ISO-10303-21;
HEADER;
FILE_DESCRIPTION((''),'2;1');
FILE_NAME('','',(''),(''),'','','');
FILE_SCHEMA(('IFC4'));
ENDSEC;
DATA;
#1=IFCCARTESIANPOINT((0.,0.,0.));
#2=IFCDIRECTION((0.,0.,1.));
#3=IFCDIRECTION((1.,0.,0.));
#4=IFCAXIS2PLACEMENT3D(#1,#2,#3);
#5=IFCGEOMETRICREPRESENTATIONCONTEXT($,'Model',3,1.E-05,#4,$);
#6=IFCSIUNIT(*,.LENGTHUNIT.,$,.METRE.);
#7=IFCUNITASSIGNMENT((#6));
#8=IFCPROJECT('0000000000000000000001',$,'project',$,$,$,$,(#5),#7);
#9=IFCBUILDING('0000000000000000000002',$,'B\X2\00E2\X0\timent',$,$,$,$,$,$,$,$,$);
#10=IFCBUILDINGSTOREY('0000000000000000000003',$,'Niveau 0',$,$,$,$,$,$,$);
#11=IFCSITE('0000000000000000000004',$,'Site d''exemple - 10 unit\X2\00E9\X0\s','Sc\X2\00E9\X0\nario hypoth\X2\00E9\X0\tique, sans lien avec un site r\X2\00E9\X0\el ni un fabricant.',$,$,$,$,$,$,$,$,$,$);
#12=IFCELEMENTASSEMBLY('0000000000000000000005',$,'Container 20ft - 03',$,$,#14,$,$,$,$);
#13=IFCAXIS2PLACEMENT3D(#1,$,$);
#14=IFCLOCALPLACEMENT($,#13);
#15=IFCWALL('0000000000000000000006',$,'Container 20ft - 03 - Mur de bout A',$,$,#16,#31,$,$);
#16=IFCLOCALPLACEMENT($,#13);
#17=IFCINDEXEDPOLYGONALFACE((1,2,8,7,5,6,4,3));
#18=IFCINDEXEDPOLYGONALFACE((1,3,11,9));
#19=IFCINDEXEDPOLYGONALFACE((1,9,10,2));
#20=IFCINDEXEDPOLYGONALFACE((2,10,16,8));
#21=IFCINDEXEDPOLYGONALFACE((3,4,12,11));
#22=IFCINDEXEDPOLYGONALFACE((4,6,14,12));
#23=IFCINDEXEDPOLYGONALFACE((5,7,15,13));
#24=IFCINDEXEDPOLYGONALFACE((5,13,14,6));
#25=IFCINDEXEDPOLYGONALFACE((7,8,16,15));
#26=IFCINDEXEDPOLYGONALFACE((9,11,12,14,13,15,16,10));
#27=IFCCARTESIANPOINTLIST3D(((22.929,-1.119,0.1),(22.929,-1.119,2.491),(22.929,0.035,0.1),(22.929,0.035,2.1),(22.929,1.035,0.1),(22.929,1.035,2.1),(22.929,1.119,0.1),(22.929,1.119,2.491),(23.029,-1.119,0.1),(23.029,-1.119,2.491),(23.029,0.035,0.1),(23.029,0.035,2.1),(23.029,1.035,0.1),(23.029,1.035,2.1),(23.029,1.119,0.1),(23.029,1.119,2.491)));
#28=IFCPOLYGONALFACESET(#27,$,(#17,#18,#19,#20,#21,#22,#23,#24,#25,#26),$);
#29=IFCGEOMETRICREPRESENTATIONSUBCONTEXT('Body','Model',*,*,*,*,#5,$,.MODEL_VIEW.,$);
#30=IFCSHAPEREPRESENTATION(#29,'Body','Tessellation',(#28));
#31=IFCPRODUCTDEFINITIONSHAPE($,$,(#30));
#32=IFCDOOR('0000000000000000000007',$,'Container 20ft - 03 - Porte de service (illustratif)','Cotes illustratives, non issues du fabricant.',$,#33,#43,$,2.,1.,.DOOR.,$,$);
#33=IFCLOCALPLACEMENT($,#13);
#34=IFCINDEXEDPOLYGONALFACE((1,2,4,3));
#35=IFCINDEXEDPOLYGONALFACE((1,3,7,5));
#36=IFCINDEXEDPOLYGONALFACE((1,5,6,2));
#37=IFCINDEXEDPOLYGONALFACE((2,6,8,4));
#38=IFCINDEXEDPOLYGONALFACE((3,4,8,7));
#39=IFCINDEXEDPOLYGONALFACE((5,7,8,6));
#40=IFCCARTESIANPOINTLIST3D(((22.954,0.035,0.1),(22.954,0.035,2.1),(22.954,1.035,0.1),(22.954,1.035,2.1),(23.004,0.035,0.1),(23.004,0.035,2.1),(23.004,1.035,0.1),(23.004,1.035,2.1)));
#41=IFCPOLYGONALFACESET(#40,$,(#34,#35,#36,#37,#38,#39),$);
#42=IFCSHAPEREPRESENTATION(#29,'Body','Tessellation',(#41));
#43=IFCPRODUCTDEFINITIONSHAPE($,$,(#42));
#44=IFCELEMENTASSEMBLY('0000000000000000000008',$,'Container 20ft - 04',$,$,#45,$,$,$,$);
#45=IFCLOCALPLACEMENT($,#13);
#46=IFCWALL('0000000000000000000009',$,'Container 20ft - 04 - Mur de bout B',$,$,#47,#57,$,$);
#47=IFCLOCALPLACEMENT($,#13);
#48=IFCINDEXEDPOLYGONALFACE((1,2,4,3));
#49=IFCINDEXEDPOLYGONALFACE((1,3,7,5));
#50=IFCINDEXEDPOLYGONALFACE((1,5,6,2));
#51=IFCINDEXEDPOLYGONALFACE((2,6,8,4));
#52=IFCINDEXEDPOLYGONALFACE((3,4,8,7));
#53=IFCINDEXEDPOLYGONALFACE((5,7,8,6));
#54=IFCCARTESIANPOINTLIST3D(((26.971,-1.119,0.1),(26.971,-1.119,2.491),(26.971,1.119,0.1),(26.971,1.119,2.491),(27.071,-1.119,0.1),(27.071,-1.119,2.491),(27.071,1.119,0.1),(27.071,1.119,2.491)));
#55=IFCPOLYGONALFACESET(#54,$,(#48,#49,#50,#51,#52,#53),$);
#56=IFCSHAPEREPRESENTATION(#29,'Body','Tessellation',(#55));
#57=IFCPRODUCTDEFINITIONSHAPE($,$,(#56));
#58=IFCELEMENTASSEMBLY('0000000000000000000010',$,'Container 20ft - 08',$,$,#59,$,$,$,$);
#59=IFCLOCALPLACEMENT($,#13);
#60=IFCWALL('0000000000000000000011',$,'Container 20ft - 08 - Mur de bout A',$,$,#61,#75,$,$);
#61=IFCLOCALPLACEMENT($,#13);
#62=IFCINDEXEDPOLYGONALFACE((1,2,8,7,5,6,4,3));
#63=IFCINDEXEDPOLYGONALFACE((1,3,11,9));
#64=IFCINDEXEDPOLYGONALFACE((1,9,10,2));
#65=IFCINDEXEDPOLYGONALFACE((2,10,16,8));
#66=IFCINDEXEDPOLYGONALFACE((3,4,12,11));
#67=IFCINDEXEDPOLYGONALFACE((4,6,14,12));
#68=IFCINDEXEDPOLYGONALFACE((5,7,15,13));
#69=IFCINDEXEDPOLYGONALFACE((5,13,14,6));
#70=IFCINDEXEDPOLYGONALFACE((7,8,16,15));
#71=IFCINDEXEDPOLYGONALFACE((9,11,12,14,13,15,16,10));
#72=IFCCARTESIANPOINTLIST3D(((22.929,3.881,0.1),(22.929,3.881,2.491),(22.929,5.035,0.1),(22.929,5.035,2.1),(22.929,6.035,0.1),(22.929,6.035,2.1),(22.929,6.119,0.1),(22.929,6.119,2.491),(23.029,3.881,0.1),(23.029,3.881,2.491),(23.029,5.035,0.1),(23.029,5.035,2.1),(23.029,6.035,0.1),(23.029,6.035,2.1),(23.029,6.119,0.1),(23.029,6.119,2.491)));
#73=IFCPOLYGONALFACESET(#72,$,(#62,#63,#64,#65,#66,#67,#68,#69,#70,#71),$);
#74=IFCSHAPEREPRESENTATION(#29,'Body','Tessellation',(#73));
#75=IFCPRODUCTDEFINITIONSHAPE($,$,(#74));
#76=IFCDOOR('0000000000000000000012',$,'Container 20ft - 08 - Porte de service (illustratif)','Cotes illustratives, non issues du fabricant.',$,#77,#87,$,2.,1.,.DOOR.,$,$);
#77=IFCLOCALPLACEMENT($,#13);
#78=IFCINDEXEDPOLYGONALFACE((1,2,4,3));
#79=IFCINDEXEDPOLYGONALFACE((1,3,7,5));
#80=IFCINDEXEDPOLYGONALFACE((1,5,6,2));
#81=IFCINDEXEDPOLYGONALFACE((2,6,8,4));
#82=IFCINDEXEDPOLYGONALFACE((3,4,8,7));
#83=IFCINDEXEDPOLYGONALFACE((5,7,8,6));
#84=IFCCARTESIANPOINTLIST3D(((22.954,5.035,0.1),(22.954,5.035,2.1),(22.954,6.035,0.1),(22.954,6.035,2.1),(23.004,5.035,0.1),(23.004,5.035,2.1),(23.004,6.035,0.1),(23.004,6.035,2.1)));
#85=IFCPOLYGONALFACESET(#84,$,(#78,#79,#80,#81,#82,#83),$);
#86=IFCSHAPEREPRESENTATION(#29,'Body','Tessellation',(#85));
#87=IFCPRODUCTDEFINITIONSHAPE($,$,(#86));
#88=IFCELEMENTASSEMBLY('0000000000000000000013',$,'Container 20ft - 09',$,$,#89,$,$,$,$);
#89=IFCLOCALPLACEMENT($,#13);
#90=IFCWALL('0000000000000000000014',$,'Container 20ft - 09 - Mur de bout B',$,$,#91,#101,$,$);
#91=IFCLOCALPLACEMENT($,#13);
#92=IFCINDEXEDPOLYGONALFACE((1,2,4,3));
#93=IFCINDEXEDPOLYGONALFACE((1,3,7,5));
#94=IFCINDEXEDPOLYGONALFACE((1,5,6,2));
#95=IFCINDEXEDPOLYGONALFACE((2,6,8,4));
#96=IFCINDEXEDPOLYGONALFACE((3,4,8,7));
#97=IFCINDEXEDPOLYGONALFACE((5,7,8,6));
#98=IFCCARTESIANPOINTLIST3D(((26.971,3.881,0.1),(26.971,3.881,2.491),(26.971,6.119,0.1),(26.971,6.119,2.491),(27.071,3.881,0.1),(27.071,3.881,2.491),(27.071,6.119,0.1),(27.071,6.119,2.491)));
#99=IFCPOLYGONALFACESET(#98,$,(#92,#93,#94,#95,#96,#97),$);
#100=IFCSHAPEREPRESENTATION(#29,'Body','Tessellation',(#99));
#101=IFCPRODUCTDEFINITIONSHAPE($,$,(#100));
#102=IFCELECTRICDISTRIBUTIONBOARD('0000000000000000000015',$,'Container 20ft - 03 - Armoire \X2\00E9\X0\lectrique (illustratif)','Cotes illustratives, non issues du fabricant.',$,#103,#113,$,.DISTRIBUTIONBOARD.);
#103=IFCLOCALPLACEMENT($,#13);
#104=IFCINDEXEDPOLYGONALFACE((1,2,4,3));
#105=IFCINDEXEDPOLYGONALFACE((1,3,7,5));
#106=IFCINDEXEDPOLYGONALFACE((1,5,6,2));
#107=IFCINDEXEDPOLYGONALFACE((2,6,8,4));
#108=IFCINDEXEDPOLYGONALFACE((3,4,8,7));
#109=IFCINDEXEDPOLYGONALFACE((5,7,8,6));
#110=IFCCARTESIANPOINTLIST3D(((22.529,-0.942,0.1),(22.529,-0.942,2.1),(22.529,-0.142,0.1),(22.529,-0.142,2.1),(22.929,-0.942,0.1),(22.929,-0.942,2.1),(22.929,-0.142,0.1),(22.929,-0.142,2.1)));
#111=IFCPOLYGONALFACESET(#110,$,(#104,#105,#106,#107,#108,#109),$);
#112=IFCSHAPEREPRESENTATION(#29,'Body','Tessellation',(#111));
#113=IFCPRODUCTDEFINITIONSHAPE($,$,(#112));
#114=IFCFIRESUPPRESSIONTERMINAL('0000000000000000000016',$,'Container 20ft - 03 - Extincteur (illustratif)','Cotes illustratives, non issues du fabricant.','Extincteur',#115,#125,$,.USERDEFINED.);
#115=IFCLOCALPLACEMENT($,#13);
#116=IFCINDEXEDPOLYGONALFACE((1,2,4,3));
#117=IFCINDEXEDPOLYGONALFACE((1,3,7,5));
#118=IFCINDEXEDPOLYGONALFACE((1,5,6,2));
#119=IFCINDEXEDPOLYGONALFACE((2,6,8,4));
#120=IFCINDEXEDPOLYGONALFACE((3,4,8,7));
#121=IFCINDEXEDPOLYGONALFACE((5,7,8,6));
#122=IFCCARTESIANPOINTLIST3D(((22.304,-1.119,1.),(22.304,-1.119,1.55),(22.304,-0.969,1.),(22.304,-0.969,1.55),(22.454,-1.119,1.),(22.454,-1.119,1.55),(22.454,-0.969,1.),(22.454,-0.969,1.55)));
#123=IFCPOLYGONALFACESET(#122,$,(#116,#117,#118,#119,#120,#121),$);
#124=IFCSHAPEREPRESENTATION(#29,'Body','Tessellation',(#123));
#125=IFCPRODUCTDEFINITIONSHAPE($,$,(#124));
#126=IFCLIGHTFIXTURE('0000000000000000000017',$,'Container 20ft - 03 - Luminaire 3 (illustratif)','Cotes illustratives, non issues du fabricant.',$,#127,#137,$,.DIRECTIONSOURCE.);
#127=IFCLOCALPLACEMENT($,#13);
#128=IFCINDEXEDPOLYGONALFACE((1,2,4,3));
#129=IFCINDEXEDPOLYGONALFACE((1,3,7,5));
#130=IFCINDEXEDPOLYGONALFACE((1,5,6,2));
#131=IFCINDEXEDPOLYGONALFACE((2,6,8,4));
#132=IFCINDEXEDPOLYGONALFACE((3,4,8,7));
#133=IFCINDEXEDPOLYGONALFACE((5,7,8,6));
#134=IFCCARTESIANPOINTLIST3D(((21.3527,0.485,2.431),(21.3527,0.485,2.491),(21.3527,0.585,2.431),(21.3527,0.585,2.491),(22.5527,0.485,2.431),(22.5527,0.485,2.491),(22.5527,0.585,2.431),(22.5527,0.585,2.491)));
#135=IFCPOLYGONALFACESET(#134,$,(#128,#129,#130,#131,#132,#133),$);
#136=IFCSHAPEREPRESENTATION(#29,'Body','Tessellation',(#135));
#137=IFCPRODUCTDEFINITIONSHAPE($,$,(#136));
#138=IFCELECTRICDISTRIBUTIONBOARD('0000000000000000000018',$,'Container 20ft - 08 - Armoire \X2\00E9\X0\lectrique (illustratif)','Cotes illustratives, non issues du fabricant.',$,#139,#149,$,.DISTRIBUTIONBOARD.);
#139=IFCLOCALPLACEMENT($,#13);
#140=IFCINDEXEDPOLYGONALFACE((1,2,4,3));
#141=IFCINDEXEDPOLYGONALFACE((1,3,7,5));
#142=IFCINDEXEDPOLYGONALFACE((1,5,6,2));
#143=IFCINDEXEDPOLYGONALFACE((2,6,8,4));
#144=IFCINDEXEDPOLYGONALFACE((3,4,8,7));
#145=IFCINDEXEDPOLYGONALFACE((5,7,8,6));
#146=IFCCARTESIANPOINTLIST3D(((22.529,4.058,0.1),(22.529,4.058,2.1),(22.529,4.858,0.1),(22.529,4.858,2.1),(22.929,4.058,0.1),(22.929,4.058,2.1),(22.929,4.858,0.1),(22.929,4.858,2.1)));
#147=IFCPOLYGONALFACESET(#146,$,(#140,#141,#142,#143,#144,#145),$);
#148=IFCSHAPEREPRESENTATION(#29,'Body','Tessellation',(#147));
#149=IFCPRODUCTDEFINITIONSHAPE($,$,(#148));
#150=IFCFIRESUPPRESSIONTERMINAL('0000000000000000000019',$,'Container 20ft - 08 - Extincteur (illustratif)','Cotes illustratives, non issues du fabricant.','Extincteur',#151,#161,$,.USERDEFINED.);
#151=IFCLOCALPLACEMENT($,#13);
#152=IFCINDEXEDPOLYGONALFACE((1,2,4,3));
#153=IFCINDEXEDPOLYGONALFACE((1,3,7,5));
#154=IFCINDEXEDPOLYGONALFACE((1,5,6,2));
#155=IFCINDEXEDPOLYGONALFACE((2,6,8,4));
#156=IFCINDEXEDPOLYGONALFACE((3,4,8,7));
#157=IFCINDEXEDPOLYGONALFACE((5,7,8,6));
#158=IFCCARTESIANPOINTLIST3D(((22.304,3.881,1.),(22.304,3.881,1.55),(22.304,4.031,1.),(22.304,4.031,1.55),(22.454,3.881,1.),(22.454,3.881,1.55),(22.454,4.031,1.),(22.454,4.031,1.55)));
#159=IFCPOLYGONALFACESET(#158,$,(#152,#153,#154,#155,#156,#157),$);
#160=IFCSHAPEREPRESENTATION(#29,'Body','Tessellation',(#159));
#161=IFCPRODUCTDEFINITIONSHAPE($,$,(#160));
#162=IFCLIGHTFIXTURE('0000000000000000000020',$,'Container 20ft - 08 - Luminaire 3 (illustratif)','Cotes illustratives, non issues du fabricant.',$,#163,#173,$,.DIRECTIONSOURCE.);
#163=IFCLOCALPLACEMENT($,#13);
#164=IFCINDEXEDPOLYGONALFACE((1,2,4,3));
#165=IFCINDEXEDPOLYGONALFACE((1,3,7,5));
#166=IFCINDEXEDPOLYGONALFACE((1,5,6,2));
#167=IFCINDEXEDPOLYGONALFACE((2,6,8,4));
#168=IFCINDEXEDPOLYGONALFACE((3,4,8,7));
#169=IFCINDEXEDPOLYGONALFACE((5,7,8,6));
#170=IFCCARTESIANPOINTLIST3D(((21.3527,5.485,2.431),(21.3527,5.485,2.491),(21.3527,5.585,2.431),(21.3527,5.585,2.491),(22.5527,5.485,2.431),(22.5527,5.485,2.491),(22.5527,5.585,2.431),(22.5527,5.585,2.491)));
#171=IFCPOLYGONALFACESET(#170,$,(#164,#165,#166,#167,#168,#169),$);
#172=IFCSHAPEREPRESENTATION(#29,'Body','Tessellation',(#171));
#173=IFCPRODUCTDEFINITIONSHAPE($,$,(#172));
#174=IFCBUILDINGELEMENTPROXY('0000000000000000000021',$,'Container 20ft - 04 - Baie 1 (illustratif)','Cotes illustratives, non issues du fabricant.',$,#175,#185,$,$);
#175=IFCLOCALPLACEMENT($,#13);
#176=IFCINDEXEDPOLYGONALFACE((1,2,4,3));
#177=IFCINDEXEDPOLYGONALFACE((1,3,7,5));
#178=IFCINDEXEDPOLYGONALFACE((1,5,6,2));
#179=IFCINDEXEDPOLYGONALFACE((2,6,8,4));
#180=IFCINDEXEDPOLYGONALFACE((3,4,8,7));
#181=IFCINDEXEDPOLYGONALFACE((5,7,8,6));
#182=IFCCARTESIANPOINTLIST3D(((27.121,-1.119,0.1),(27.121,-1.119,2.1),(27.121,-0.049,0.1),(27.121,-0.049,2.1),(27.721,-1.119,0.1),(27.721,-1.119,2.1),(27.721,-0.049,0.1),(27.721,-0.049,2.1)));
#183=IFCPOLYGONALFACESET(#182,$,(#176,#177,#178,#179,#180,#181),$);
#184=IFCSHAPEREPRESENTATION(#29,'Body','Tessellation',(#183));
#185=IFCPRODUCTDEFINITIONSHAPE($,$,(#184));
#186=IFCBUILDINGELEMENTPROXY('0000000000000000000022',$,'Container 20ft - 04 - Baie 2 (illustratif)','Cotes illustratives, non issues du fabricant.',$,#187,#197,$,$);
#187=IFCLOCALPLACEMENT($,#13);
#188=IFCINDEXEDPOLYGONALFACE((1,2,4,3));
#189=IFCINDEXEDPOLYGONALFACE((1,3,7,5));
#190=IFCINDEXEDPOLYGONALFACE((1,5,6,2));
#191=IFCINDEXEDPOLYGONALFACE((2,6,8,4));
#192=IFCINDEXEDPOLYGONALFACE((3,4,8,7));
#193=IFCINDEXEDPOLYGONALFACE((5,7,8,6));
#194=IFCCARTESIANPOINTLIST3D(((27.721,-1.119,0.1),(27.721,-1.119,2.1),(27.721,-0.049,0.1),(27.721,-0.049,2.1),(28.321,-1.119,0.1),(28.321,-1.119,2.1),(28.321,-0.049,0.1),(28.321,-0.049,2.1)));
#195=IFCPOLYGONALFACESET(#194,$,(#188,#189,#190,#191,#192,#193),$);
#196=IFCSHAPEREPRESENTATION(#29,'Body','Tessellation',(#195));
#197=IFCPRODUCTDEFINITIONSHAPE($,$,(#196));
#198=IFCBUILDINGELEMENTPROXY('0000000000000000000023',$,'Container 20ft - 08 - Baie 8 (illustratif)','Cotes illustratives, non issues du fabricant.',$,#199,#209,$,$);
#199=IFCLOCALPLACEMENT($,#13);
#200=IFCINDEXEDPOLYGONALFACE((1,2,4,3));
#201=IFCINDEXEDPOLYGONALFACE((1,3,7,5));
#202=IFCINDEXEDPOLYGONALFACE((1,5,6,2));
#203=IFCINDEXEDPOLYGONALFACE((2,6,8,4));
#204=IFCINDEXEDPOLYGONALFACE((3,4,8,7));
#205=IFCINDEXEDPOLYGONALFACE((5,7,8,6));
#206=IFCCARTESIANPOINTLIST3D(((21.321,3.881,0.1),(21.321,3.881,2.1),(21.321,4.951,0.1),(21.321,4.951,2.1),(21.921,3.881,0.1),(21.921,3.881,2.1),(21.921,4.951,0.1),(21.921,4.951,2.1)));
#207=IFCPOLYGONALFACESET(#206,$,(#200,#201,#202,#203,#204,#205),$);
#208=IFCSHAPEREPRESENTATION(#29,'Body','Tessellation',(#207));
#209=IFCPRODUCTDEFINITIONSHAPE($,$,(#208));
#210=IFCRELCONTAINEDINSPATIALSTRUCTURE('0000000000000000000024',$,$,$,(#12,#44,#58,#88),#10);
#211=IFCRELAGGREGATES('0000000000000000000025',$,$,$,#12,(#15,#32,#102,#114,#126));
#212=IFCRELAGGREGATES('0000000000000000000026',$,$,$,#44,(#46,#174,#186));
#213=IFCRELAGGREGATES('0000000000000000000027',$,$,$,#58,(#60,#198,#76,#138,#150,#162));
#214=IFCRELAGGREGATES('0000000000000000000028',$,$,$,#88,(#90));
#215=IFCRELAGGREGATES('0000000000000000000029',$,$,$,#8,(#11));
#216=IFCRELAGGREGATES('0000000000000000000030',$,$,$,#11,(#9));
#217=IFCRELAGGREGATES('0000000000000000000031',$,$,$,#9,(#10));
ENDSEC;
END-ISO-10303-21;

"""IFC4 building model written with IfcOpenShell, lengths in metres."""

from ifc_helpers import new_model, si_unit, frame, origin_with_axes, place, context, subcontext, project, spatial, rectangle, extrude, element, fill, aggregate, save


model = new_model("IFC4")

# Units and contexts
model_context = context("Model", 3, precision=1e-05, world=origin_with_axes())
body_context = subcontext(model_context, "Body", "Model", "MODEL_VIEW")
ifc_project = project(units=[si_unit("LENGTHUNIT", "METRE")], contexts=[model_context])

# Site, building, storey
site = spatial("IfcSite", under=ifc_project, Name="Site d'exemple - 10 unités", Description="Scénario hypothétique, sans lien avec un site réel ni un fabricant.")
building = spatial("IfcBuilding", under=site, Name="Bâtiment")
storey = spatial("IfcBuildingStorey", under=building, Name="Niveau 0")

# Element assembly, wall, opening, door
assembly_1 = element("IfcElementAssembly", 1, inside=storey, Name="Container 20ft - 03")
wall_1_placement = place(None, frame((22.979, 0.0, 0.1), z_axis=(0.0, 0.0, 1.0), x_axis=(1.0, 0.0, 0.0)))
wall_1 = element("IfcWall", 2, at=wall_1_placement, Name="Container 20ft - 03 - Mur de bout A", context=body_context, shape_type="SweptSolid", body=[
    extrude(rectangle(XDim=0.1, YDim=2.238), origin_with_axes(), (0.0, 0.0, 1.0), 2.391),
])
opening_1_placement = place(None, frame((22.979, 0.535, 0.1), z_axis=(0.0, 0.0, 1.0), x_axis=(1.0, 0.0, 0.0)))
opening_1 = element("IfcOpeningElement", 3, at=opening_1_placement, cuts=wall_1, PredefinedType="OPENING", context=body_context, shape_type="SweptSolid", body=[
    extrude(rectangle(XDim=0.2, YDim=1.0), origin_with_axes(), (0.0, 0.0, 1.0), 2.0),
])
door_1_placement = place(None, frame((22.979, 0.535, 0.1), z_axis=(0.0, 0.0, 1.0), x_axis=(1.0, 0.0, 0.0)))
door_1 = element("IfcDoor", 4, at=door_1_placement, Name="Container 20ft - 03 - Porte de service (illustratif)", Description="Cotes illustratives, non issues du fabricant.", OverallHeight=2.0, OverallWidth=1.0, PredefinedType="DOOR", context=body_context, shape_type="SweptSolid", body=[
    extrude(rectangle(XDim=0.05, YDim=1.0), origin_with_axes(), (0.0, 0.0, 1.0), 2.0),
])
fill(opening_1, door_1)

# Element assembly, wall
assembly_2 = element("IfcElementAssembly", 5, inside=storey, Name="Container 20ft - 04")
wall_2_placement = place(None, frame((27.021, 0.0, 0.1), z_axis=(0.0, 0.0, 1.0), x_axis=(1.0, 0.0, 0.0)))
wall_2 = element("IfcWall", 6, at=wall_2_placement, Name="Container 20ft - 04 - Mur de bout B", context=body_context, shape_type="SweptSolid", body=[
    extrude(rectangle(XDim=0.1, YDim=2.238), origin_with_axes(), (0.0, 0.0, 1.0), 2.391),
])

# Element assembly, wall, opening, door
assembly_3 = element("IfcElementAssembly", 7, inside=storey, Name="Container 20ft - 08")
wall_3_placement = place(None, frame((22.979, 5.0, 0.1), z_axis=(0.0, 0.0, 1.0), x_axis=(1.0, 0.0, 0.0)))
wall_3 = element("IfcWall", 8, at=wall_3_placement, Name="Container 20ft - 08 - Mur de bout A", context=body_context, shape_type="SweptSolid", body=[
    extrude(rectangle(XDim=0.1, YDim=2.238), origin_with_axes(), (0.0, 0.0, 1.0), 2.391),
])
opening_2_placement = place(None, frame((22.979, 5.535, 0.1), z_axis=(0.0, 0.0, 1.0), x_axis=(1.0, 0.0, 0.0)))
opening_2 = element("IfcOpeningElement", 9, at=opening_2_placement, cuts=wall_3, PredefinedType="OPENING", context=body_context, shape_type="SweptSolid", body=[
    extrude(rectangle(XDim=0.2, YDim=1.0), origin_with_axes(), (0.0, 0.0, 1.0), 2.0),
])
door_2_placement = place(None, frame((22.979, 5.535, 0.1), z_axis=(0.0, 0.0, 1.0), x_axis=(1.0, 0.0, 0.0)))
door_2 = element("IfcDoor", 10, at=door_2_placement, Name="Container 20ft - 08 - Porte de service (illustratif)", Description="Cotes illustratives, non issues du fabricant.", OverallHeight=2.0, OverallWidth=1.0, PredefinedType="DOOR", context=body_context, shape_type="SweptSolid", body=[
    extrude(rectangle(XDim=0.05, YDim=1.0), origin_with_axes(), (0.0, 0.0, 1.0), 2.0),
])
fill(opening_2, door_2)

# Element assembly, wall
assembly_4 = element("IfcElementAssembly", 11, inside=storey, Name="Container 20ft - 09")
wall_4_placement = place(None, frame((27.021, 5.0, 0.1), z_axis=(0.0, 0.0, 1.0), x_axis=(1.0, 0.0, 0.0)))
wall_4 = element("IfcWall", 12, at=wall_4_placement, Name="Container 20ft - 09 - Mur de bout B", context=body_context, shape_type="SweptSolid", body=[
    extrude(rectangle(XDim=0.1, YDim=2.238), origin_with_axes(), (0.0, 0.0, 1.0), 2.391),
])

# Electric distribution board
electric_distribution_board_1_placement = place(None, frame((22.729, -0.542, 0.1), z_axis=(0.0, 0.0, 1.0), x_axis=(1.0, 0.0, 0.0)))
electric_distribution_board_1 = element("IfcElectricDistributionBoard", 13, at=electric_distribution_board_1_placement, Name="Container 20ft - 03 - Armoire électrique (illustratif)", Description="Cotes illustratives, non issues du fabricant.", PredefinedType="DISTRIBUTIONBOARD", context=body_context, shape_type="SweptSolid", body=[
    extrude(rectangle(XDim=0.4, YDim=0.8), origin_with_axes(), (0.0, 0.0, 1.0), 2.0),
])

# Fire suppression terminal
fire_suppression_terminal_1_placement = place(None, frame((22.379, -1.044, 1.0), z_axis=(0.0, 0.0, 1.0), x_axis=(1.0, 0.0, 0.0)))
fire_suppression_terminal_1 = element("IfcFireSuppressionTerminal", 14, at=fire_suppression_terminal_1_placement, Name="Container 20ft - 03 - Extincteur (illustratif)", Description="Cotes illustratives, non issues du fabricant.", ObjectType="Extincteur", PredefinedType="USERDEFINED", context=body_context, shape_type="SweptSolid", body=[
    extrude(rectangle(XDim=0.15, YDim=0.15), origin_with_axes(), (0.0, 0.0, 1.0), 0.55),
])

# Light fixture
light_fixture_1_placement = place(None, frame((21.9527, 0.535, 2.431), z_axis=(0.0, 0.0, 1.0), x_axis=(1.0, 0.0, 0.0)))
light_fixture_1 = element("IfcLightFixture", 15, at=light_fixture_1_placement, Name="Container 20ft - 03 - Luminaire 3 (illustratif)", Description="Cotes illustratives, non issues du fabricant.", PredefinedType="DIRECTIONSOURCE", context=body_context, shape_type="SweptSolid", body=[
    extrude(rectangle(XDim=1.2, YDim=0.1), origin_with_axes(), (0.0, 0.0, 1.0), 0.06),
])
aggregate(assembly_1, [wall_1, door_1, electric_distribution_board_1, fire_suppression_terminal_1, light_fixture_1])

# Electric distribution board
electric_distribution_board_2_placement = place(None, frame((22.729, 4.458, 0.1), z_axis=(0.0, 0.0, 1.0), x_axis=(1.0, 0.0, 0.0)))
electric_distribution_board_2 = element("IfcElectricDistributionBoard", 16, at=electric_distribution_board_2_placement, Name="Container 20ft - 08 - Armoire électrique (illustratif)", Description="Cotes illustratives, non issues du fabricant.", PredefinedType="DISTRIBUTIONBOARD", context=body_context, shape_type="SweptSolid", body=[
    extrude(rectangle(XDim=0.4, YDim=0.8), origin_with_axes(), (0.0, 0.0, 1.0), 2.0),
])

# Fire suppression terminal
fire_suppression_terminal_2_placement = place(None, frame((22.379, 3.956, 1.0), z_axis=(0.0, 0.0, 1.0), x_axis=(1.0, 0.0, 0.0)))
fire_suppression_terminal_2 = element("IfcFireSuppressionTerminal", 17, at=fire_suppression_terminal_2_placement, Name="Container 20ft - 08 - Extincteur (illustratif)", Description="Cotes illustratives, non issues du fabricant.", ObjectType="Extincteur", PredefinedType="USERDEFINED", context=body_context, shape_type="SweptSolid", body=[
    extrude(rectangle(XDim=0.15, YDim=0.15), origin_with_axes(), (0.0, 0.0, 1.0), 0.55),
])

# Light fixture
light_fixture_2_placement = place(None, frame((21.9527, 5.535, 2.431), z_axis=(0.0, 0.0, 1.0), x_axis=(1.0, 0.0, 0.0)))
light_fixture_2 = element("IfcLightFixture", 18, at=light_fixture_2_placement, Name="Container 20ft - 08 - Luminaire 3 (illustratif)", Description="Cotes illustratives, non issues du fabricant.", PredefinedType="DIRECTIONSOURCE", context=body_context, shape_type="SweptSolid", body=[
    extrude(rectangle(XDim=1.2, YDim=0.1), origin_with_axes(), (0.0, 0.0, 1.0), 0.06),
])

# Building element proxies
proxy_1_placement = place(None, frame((27.421, -0.584, 0.1), z_axis=(0.0, 0.0, 1.0), x_axis=(1.0, 0.0, 0.0)))
proxy_1 = element("IfcBuildingElementProxy", 19, at=proxy_1_placement, Name="Container 20ft - 04 - Baie 1 (illustratif)", Description="Cotes illustratives, non issues du fabricant.", context=body_context, shape_type="SweptSolid", body=[
    extrude(rectangle(XDim=0.6, YDim=1.07), origin_with_axes(), (0.0, 0.0, 1.0), 2.0),
])
proxy_2_placement = place(None, frame((28.021, -0.584, 0.1), z_axis=(0.0, 0.0, 1.0), x_axis=(1.0, 0.0, 0.0)))
proxy_2 = element("IfcBuildingElementProxy", 20, at=proxy_2_placement, Name="Container 20ft - 04 - Baie 2 (illustratif)", Description="Cotes illustratives, non issues du fabricant.", context=body_context, shape_type="SweptSolid", body=[
    extrude(rectangle(XDim=0.6, YDim=1.07), origin_with_axes(), (0.0, 0.0, 1.0), 2.0),
])
aggregate(assembly_2, [wall_2, proxy_1, proxy_2])
proxy_3_placement = place(None, frame((21.621, 4.416, 0.1), z_axis=(0.0, 0.0, 1.0), x_axis=(1.0, 0.0, 0.0)))
proxy_3 = element("IfcBuildingElementProxy", 21, at=proxy_3_placement, Name="Container 20ft - 08 - Baie 8 (illustratif)", Description="Cotes illustratives, non issues du fabricant.", context=body_context, shape_type="SweptSolid", body=[
    extrude(rectangle(XDim=0.6, YDim=1.07), origin_with_axes(), (0.0, 0.0, 1.0), 2.0),
])
aggregate(assembly_3, [wall_3, proxy_3, door_2, electric_distribution_board_2, fire_suppression_terminal_2, light_fixture_2])
aggregate(assembly_4, [wall_4])

save(model, "model.ifc")
